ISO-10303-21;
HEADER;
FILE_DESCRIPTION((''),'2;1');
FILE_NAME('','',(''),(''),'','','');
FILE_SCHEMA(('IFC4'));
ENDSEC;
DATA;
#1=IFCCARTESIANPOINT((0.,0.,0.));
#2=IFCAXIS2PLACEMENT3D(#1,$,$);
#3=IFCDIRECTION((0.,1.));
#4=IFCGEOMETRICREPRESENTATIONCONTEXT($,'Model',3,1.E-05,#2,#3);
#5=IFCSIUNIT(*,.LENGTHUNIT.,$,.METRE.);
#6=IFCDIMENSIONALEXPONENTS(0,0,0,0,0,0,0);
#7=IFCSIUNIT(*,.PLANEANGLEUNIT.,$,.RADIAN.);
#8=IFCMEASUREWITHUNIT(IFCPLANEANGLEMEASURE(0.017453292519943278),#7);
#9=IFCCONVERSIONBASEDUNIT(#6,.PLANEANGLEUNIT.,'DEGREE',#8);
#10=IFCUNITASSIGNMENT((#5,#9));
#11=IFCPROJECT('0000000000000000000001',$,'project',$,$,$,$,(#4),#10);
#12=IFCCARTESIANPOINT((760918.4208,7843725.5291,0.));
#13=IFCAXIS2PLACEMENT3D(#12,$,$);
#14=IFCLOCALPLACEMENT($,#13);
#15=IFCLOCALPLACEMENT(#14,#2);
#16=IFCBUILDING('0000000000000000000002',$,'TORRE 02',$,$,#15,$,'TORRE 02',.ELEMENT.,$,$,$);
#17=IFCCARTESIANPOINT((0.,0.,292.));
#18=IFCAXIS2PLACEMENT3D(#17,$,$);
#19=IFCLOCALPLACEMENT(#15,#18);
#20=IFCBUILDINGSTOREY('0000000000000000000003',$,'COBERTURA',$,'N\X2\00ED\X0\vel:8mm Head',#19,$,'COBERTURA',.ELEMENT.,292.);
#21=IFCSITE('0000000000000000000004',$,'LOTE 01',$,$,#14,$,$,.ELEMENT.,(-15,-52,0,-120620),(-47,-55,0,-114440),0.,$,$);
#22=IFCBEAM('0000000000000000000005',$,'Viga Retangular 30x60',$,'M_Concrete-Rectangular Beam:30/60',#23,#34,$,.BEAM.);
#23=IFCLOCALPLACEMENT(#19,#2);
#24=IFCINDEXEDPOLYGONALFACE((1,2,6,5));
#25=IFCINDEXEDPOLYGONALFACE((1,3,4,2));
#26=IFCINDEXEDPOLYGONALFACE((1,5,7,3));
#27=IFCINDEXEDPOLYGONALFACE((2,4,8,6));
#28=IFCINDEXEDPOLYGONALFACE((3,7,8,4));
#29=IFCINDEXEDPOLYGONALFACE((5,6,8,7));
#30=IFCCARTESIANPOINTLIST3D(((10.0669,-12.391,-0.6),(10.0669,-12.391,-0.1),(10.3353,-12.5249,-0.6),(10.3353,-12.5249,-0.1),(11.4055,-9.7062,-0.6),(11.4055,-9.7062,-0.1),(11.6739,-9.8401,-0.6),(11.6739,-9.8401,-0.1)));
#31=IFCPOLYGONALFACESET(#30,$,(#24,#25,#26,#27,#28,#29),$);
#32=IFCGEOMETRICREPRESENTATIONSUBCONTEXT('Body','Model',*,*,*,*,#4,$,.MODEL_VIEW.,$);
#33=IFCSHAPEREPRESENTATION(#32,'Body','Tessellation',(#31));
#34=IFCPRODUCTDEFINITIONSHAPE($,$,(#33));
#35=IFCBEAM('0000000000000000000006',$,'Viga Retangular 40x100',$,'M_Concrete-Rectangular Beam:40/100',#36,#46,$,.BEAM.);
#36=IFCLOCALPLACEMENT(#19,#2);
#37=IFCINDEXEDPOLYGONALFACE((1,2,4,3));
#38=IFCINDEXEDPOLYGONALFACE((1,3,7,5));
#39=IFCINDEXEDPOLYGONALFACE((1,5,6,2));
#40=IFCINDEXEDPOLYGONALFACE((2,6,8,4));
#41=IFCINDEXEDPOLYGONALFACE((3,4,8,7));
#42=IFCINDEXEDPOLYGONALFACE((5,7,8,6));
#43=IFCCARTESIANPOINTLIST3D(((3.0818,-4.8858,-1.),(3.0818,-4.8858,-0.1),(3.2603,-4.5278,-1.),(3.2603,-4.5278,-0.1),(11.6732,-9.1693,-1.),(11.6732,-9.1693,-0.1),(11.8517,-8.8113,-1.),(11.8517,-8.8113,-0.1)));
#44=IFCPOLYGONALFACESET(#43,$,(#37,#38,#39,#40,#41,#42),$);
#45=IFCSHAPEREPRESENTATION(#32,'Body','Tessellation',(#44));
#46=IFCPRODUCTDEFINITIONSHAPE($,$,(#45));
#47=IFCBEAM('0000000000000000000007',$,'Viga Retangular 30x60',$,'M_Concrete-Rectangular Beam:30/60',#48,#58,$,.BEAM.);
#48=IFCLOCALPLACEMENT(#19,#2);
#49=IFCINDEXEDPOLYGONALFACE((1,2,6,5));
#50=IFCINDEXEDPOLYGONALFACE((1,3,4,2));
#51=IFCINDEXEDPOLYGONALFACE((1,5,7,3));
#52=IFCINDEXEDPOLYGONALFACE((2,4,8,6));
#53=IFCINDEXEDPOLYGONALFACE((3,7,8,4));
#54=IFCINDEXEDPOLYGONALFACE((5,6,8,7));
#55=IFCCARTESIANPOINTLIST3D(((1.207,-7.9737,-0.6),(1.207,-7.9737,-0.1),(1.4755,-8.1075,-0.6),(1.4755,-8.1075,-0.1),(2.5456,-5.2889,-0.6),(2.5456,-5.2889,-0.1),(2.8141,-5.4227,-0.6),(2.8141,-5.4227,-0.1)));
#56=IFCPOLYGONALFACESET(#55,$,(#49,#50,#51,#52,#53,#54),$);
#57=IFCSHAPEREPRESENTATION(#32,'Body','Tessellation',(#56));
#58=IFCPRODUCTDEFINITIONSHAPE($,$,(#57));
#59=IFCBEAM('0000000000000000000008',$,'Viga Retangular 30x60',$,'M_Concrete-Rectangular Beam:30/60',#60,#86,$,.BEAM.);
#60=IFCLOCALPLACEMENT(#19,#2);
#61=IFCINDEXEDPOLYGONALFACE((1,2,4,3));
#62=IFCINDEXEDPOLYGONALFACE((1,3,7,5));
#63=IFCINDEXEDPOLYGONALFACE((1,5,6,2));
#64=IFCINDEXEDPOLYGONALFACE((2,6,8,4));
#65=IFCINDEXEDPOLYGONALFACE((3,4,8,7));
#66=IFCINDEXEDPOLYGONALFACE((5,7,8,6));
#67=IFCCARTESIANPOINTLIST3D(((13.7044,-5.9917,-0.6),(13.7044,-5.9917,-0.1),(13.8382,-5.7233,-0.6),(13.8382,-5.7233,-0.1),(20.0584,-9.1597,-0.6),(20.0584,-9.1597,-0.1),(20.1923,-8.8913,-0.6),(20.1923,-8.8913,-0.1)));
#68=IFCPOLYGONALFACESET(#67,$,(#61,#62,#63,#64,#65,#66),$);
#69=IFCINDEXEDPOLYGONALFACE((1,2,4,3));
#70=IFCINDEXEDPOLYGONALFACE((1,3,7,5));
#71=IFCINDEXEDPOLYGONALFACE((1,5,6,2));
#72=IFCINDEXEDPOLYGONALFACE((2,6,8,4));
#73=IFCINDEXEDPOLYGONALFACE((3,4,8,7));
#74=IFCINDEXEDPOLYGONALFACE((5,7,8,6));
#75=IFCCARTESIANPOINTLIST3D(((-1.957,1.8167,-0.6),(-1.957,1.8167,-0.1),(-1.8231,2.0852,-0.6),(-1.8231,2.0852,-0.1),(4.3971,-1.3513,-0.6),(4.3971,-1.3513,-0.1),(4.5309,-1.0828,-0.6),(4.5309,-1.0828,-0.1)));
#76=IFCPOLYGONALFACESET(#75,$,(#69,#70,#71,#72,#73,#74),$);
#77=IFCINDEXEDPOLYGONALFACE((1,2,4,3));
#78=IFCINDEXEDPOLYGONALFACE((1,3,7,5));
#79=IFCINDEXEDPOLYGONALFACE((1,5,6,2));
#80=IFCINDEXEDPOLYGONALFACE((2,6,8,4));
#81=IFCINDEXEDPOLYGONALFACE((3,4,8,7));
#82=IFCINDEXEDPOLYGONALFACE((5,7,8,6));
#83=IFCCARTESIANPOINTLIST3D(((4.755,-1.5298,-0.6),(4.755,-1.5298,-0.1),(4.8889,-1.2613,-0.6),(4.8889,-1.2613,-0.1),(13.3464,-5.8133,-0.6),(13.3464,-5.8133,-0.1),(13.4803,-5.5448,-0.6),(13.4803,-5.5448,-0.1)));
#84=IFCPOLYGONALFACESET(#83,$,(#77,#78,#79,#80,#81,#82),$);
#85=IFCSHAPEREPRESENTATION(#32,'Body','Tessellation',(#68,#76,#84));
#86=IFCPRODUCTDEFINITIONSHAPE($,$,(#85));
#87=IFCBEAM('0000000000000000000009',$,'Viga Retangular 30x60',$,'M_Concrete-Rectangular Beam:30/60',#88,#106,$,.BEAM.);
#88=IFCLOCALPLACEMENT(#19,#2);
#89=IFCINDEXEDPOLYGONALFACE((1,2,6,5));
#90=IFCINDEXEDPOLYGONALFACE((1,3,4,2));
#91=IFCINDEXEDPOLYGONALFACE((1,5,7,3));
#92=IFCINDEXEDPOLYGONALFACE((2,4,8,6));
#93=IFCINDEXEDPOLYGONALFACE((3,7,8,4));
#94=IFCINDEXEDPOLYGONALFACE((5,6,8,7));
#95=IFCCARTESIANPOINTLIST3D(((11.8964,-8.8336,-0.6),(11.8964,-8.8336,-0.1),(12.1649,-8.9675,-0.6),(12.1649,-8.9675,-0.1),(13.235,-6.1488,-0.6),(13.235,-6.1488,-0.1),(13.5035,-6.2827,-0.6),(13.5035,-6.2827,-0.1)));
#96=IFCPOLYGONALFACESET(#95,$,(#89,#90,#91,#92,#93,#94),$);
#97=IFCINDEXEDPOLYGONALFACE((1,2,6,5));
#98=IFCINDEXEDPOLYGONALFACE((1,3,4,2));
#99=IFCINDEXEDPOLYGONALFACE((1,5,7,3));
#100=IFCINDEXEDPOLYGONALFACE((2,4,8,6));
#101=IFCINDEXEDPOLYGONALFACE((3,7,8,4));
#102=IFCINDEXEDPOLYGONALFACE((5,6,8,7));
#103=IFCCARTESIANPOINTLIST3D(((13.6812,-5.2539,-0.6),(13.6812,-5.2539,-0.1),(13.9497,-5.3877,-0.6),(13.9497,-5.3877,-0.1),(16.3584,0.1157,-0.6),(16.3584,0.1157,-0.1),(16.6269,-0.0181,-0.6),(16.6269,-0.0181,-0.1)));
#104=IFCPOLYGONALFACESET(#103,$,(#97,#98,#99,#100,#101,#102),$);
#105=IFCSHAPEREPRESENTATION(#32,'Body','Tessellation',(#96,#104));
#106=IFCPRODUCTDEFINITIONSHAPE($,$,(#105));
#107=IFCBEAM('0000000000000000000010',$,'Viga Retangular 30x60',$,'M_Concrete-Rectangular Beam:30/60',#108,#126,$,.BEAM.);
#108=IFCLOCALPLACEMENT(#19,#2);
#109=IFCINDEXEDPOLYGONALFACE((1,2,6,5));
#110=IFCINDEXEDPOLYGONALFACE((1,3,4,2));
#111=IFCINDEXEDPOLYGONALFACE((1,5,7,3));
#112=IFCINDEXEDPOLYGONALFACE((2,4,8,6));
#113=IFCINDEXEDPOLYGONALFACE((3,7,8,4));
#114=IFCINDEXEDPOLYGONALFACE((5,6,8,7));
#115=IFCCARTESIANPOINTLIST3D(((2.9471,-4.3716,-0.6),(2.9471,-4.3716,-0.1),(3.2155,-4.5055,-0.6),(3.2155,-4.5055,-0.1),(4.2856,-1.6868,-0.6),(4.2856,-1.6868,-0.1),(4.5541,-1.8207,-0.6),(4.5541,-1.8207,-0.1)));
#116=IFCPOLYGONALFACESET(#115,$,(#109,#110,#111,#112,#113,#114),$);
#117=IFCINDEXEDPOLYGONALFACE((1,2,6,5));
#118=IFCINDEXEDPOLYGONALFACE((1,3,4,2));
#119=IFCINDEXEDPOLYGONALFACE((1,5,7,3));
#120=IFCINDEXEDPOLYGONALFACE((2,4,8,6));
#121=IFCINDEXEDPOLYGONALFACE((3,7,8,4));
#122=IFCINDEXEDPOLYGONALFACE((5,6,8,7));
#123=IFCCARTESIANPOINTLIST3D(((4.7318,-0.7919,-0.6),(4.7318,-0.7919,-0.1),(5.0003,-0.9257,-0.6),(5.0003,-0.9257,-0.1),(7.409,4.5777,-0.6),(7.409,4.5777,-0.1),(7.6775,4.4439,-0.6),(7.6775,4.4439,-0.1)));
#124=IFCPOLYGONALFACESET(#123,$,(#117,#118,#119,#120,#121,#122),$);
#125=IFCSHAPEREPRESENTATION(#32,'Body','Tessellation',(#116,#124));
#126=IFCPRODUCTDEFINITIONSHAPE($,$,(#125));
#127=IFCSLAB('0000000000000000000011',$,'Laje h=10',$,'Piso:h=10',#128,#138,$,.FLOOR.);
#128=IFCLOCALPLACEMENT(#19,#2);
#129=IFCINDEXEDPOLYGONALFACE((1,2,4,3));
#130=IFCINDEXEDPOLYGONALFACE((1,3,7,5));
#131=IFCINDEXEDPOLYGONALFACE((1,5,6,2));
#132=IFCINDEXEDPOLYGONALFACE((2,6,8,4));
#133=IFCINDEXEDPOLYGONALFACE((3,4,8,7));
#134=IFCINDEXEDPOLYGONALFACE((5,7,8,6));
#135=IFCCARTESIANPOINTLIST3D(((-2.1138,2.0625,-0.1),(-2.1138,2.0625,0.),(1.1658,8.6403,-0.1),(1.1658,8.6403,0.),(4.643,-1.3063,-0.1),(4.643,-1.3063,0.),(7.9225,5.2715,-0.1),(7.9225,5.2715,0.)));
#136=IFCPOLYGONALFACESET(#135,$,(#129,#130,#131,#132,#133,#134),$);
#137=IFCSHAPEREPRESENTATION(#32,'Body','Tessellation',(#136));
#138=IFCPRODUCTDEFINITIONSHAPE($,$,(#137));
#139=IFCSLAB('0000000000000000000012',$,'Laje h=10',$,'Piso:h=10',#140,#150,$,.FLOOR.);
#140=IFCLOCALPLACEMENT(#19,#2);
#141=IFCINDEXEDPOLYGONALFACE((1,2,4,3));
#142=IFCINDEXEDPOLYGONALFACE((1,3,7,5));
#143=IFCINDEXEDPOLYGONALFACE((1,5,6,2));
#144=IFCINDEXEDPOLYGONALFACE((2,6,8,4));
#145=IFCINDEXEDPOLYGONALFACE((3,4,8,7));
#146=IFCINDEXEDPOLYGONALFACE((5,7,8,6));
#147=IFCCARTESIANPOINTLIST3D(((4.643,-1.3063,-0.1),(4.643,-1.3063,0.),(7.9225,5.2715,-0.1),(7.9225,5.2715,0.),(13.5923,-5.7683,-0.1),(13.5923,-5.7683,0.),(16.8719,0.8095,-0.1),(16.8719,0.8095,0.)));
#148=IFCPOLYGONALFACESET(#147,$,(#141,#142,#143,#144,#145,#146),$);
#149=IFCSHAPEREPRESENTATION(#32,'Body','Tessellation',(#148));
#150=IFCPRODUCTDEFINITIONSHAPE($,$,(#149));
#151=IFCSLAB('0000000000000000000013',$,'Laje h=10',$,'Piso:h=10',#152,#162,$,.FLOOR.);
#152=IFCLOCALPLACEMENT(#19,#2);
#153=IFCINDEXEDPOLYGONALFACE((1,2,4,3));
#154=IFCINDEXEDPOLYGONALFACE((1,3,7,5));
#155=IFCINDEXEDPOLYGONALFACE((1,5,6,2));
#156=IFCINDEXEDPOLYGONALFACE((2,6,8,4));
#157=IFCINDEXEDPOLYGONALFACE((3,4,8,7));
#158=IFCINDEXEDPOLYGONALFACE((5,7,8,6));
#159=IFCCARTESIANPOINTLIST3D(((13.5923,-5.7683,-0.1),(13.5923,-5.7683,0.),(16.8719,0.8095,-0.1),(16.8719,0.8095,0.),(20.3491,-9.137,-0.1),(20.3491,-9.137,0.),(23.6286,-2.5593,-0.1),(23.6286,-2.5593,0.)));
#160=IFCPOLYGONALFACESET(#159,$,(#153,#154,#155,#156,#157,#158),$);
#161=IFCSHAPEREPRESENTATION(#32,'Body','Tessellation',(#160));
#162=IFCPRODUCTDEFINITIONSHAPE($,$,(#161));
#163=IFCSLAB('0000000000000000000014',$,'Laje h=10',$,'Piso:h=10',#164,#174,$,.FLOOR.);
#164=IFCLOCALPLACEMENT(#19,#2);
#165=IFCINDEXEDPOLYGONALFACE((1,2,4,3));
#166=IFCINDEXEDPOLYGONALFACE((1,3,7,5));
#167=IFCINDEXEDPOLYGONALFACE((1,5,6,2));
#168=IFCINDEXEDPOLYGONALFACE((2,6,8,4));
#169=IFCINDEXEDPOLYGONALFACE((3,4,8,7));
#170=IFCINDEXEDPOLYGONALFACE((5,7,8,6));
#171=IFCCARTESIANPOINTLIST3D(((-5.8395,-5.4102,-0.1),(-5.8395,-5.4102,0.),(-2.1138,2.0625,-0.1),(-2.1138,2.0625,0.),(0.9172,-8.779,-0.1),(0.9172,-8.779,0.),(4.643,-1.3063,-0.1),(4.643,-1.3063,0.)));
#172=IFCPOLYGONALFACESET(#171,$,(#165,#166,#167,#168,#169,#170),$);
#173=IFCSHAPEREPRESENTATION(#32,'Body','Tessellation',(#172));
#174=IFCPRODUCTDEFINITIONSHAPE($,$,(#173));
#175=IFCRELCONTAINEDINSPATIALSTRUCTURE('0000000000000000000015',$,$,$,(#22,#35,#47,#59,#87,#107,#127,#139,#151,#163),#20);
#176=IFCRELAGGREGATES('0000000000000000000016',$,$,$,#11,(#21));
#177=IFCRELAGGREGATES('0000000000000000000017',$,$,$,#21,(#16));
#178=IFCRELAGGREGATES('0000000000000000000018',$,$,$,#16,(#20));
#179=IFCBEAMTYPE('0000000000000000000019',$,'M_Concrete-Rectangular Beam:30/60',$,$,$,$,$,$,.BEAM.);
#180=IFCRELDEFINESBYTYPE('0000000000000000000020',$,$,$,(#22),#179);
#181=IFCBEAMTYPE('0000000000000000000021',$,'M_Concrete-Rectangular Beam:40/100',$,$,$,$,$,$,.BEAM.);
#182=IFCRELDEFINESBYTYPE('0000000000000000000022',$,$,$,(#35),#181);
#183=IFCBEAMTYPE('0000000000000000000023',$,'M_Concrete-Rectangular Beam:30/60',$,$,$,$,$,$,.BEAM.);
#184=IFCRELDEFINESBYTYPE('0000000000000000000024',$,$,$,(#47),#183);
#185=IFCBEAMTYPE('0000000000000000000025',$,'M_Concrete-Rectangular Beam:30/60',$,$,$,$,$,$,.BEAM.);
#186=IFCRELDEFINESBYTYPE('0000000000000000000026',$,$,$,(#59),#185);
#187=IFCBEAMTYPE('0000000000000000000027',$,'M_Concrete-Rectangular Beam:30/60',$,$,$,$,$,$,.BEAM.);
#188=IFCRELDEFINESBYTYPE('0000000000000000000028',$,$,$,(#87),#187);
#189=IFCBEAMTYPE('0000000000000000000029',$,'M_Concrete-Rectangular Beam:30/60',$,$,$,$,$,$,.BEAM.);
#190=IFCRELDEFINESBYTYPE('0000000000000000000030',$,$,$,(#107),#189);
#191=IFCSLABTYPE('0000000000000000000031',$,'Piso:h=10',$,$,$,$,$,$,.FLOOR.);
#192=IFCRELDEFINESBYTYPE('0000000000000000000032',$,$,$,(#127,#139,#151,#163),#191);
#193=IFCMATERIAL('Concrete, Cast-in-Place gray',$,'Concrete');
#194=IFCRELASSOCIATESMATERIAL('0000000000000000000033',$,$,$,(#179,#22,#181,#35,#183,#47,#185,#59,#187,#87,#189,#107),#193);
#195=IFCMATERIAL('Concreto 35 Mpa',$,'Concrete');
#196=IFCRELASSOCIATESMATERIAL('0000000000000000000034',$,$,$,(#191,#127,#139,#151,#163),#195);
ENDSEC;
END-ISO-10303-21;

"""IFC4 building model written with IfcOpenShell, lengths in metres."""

from ifc_helpers import new_model, entity, si_unit, converted_unit, direction, frame, origin, place, context, subcontext, project, spatial, indexed_curve, outline, extrude, source, transform, mapped, material, type_object, type_shapes, element, save


model = new_model("IFC4")

# Units and contexts
model_context = context("Model", 3, precision=1e-05, world=origin(), true_north=direction((0.0, 1.0)))
body_context = subcontext(model_context, "Body", "Model", "MODEL_VIEW")
ifc_project = project(units=[si_unit("LENGTHUNIT", "METRE"), converted_unit("PLANEANGLEUNIT", "DEGREE", entity("IfcPlaneAngleMeasure", 0.017453292519943278), si_unit("PLANEANGLEUNIT", "RADIAN"), dimensions=[0, 0, 0, 0, 0, 0, 0])], contexts=[model_context])

# Site, building, storey
site_placement = place(None, frame((760918.4208, 7843725.5291, 0.0)))
site = spatial("IfcSite", under=ifc_project, at=site_placement, Name="LOTE 01", CompositionType="ELEMENT", RefLatitude=(-15, -52, 0, -120620), RefLongitude=(-47, -55, 0, -114440), RefElevation=0.0)
building_placement = place(site_placement, origin())
building = spatial("IfcBuilding", under=site, at=building_placement, Name="TORRE 02", LongName="TORRE 02", CompositionType="ELEMENT")
storey_placement = place(building_placement, frame((0.0, 0.0, 292.0)))
storey = spatial("IfcBuildingStorey", under=building, at=storey_placement, Name="COBERTURA", ObjectType="Nível:8mm Head", LongName="COBERTURA", CompositionType="ELEMENT", Elevation=292.0)

# Beams
ifc_material_1 = material(Name="Concrete, Cast-in-Place gray", Category="Concrete")
beam_type_1 = type_object("IfcBeamType", Name="M_Concrete-Rectangular Beam:30/60", PredefinedType="BEAM", material=ifc_material_1)
shared_shape_1 = source(origin(), body_context, "Body", "SweptSolid", [
    extrude(outline(indexed_curve([(-0.25, -0.15), (0.25, -0.15), (0.25, 0.15), (-0.25, 0.15), (-0.25, -0.15)], self_intersect=False)), frame((10.2011, -12.458, 291.65), z_axis=(0.446198, 0.894934, 0.0), x_axis=(0.0, 0.0, 1.0)), (0.0, 0.0, 1.0), 3.0),
])
type_shapes(beam_type_1, [shared_shape_1])
beam_1_placement = place(storey_placement, frame((0.0, 0.0, -292.0)))
element("IfcBeam", 1, at=beam_1_placement, inside=storey, type_object=beam_type_1, material=ifc_material_1, Name="Viga Retangular 30x60", ObjectType="M_Concrete-Rectangular Beam:30/60", PredefinedType="BEAM", context=body_context, shape_type="MappedRepresentation", body=[
    mapped(shared_shape_1, transform((0.0, 0.0, 0.0), scale=1.0)),
])
beam_type_2 = type_object("IfcBeamType", Name="M_Concrete-Rectangular Beam:40/100", PredefinedType="BEAM", material=ifc_material_1)
shared_shape_2 = source(origin(), body_context, "Body", "SweptSolid", [
    extrude(outline(indexed_curve([(-0.45, -0.2), (0.45, -0.2), (0.45, 0.2), (-0.45, 0.2), (-0.45, -0.2)], self_intersect=False)), frame((11.7624, -8.9903, 291.45), z_axis=(-0.894934, 0.446198, 0.0), x_axis=(0.0, 0.0, 1.0)), (0.0, 0.0, 1.0), 9.6),
])
type_shapes(beam_type_2, [shared_shape_2])
beam_2_placement = place(storey_placement, frame((0.0, 0.0, -292.0)))
element("IfcBeam", 2, at=beam_2_placement, inside=storey, type_object=beam_type_2, material=ifc_material_1, Name="Viga Retangular 40x100", ObjectType="M_Concrete-Rectangular Beam:40/100", PredefinedType="BEAM", context=body_context, shape_type="MappedRepresentation", body=[
    mapped(shared_shape_2, transform((0.0, 0.0, 0.0), scale=1.0)),
])
beam_type_3 = type_object("IfcBeamType", Name="M_Concrete-Rectangular Beam:30/60", PredefinedType="BEAM", material=ifc_material_1)
shared_shape_3 = source(origin(), body_context, "Body", "SweptSolid", [
    extrude(outline(indexed_curve([(-0.25, -0.15), (0.25, -0.15), (0.25, 0.15), (-0.25, 0.15), (-0.25, -0.15)], self_intersect=False)), frame((2.6798, -5.3558, 291.65), z_axis=(-0.446198, -0.894934, 0.0), x_axis=(0.0, 0.0, -1.0)), (0.0, 0.0, 1.0), 3.0),
])
type_shapes(beam_type_3, [shared_shape_3])
beam_3_placement = place(storey_placement, frame((0.0, 0.0, -292.0)))
element("IfcBeam", 3, at=beam_3_placement, inside=storey, type_object=beam_type_3, material=ifc_material_1, Name="Viga Retangular 30x60", ObjectType="M_Concrete-Rectangular Beam:30/60", PredefinedType="BEAM", context=body_context, shape_type="MappedRepresentation", body=[
    mapped(shared_shape_3, transform((0.0, 0.0, 0.0), scale=1.0)),
])
beam_type_4 = type_object("IfcBeamType", Name="M_Concrete-Rectangular Beam:30/60", PredefinedType="BEAM", material=ifc_material_1)
shared_shape_4 = source(origin(), body_context, "Body", "SweptSolid", [
    extrude(outline(indexed_curve([(-0.25, -0.15), (0.25, -0.15), (0.25, 0.15), (-0.25, 0.15), (-0.25, -0.15)], self_intersect=False)), frame((13.7713, -5.8575, 291.65), z_axis=(0.894934, -0.446198, 0.0), x_axis=(0.0, 0.0, -1.0)), (0.0, 0.0, 1.0), 7.1),
    extrude(outline(indexed_curve([(-0.25, -0.15), (0.25, -0.15), (0.25, 0.15), (-0.25, 0.15), (-0.25, -0.15)], self_intersect=False)), frame((-1.89, 1.951, 291.65), z_axis=(0.894934, -0.446198, 0.0), x_axis=(0.0, 0.0, -1.0)), (0.0, 0.0, 1.0), 7.1),
    extrude(outline(indexed_curve([(-0.25, -0.15), (0.25, -0.15), (0.25, 0.15), (-0.25, 0.15), (-0.25, -0.15)], self_intersect=False)), frame((4.822, -1.3955, 291.65), z_axis=(0.894934, -0.446198, 0.0), x_axis=(0.0, 0.0, -1.0)), (0.0, 0.0, 1.0), 9.6),
])
type_shapes(beam_type_4, [shared_shape_4])
beam_4_placement = place(storey_placement, frame((0.0, 0.0, -292.0)))
element("IfcBeam", 4, at=beam_4_placement, inside=storey, type_object=beam_type_4, material=ifc_material_1, Name="Viga Retangular 30x60", ObjectType="M_Concrete-Rectangular Beam:30/60", PredefinedType="BEAM", context=body_context, shape_type="MappedRepresentation", body=[
    mapped(shared_shape_4, transform((0.0, 0.0, 0.0), scale=1.0)),
])
beam_type_5 = type_object("IfcBeamType", Name="M_Concrete-Rectangular Beam:30/60", PredefinedType="BEAM", material=ifc_material_1)
shared_shape_5 = source(origin(), body_context, "Body", "SweptSolid", [
    extrude(outline(indexed_curve([(-0.25, -0.15), (0.25, -0.15), (0.25, 0.15), (-0.25, 0.15), (-0.25, -0.15)], self_intersect=False)), frame((12.0306, -8.9005, 291.65), z_axis=(0.446198, 0.894934, 0.0), x_axis=(0.0, 0.0, 1.0)), (0.0, 0.0, 1.0), 3.0),
    extrude(outline(indexed_curve([(-0.25, -0.15), (0.25, -0.15), (0.25, 0.15), (-0.25, 0.15), (-0.25, -0.15)], self_intersect=False)), frame((13.8154, -5.3208, 291.65), z_axis=(0.446198, 0.894934, 0.0), x_axis=(0.0, 0.0, 1.0)), (0.0, 0.0, 1.0), 6.0),
])
type_shapes(beam_type_5, [shared_shape_5])
beam_5_placement = place(storey_placement, frame((0.0, 0.0, -292.0)))
element("IfcBeam", 5, at=beam_5_placement, inside=storey, type_object=beam_type_5, material=ifc_material_1, Name="Viga Retangular 30x60", ObjectType="M_Concrete-Rectangular Beam:30/60", PredefinedType="BEAM", context=body_context, shape_type="MappedRepresentation", body=[
    mapped(shared_shape_5, transform((0.0, 0.0, 0.0), scale=1.0)),
])
beam_type_6 = type_object("IfcBeamType", Name="M_Concrete-Rectangular Beam:30/60", PredefinedType="BEAM", material=ifc_material_1)
shared_shape_6 = source(origin(), body_context, "Body", "SweptSolid", [
    extrude(outline(indexed_curve([(-0.25, -0.15), (0.25, -0.15), (0.25, 0.15), (-0.25, 0.15), (-0.25, -0.15)], self_intersect=False)), frame((3.0813, -4.4385, 291.65), z_axis=(0.446198, 0.894934, 0.0), x_axis=(0.0, 0.0, 1.0)), (0.0, 0.0, 1.0), 3.0),
    extrude(outline(indexed_curve([(-0.25, -0.15), (0.25, -0.15), (0.25, 0.15), (-0.25, 0.15), (-0.25, -0.15)], self_intersect=False)), frame((4.8661, -0.8588, 291.65), z_axis=(0.446198, 0.894934, 0.0), x_axis=(0.0, 0.0, 1.0)), (0.0, 0.0, 1.0), 6.0),
])
type_shapes(beam_type_6, [shared_shape_6])
beam_6_placement = place(storey_placement, frame((0.0, 0.0, -292.0)))
element("IfcBeam", 6, at=beam_6_placement, inside=storey, type_object=beam_type_6, material=ifc_material_1, Name="Viga Retangular 30x60", ObjectType="M_Concrete-Rectangular Beam:30/60", PredefinedType="BEAM", context=body_context, shape_type="MappedRepresentation", body=[
    mapped(shared_shape_6, transform((0.0, 0.0, 0.0), scale=1.0)),
])

# Slabs
ifc_material_2 = material(Name="Concreto 35 Mpa", Category="Concrete")
slab_type = type_object("IfcSlabType", Name="Piso:h=10", PredefinedType="FLOOR", material=ifc_material_2)
slab_1_placement = place(storey_placement, origin())
element("IfcSlab", 7, at=slab_1_placement, inside=storey, type_object=slab_type, material=ifc_material_2, Name="Laje h=10", ObjectType="Piso:h=10", PredefinedType="FLOOR", context=body_context, shape_type="SweptSolid", body=[
    extrude(outline(indexed_curve([(-3.675, -3.775), (3.675, -3.775), (3.675, 3.775), (-3.675, 3.775), (-3.675, -3.775)], self_intersect=False)), frame((2.9044, 3.667, 0.0), z_axis=(0.0, 0.0, -1.0), x_axis=(-0.446198, -0.894934, 0.0)), (0.0, 0.0, 1.0), 0.1),
])
slab_2_placement = place(storey_placement, origin())
element("IfcSlab", 8, at=slab_2_placement, inside=storey, type_object=slab_type, material=ifc_material_2, Name="Laje h=10", ObjectType="Piso:h=10", PredefinedType="FLOOR", context=body_context, shape_type="SweptSolid", body=[
    extrude(outline(indexed_curve([(-3.675, -5.0), (3.675, -5.0), (3.675, 5.0), (-3.675, 5.0), (-3.675, -5.0)], self_intersect=False)), frame((10.7574, -0.2484, 0.0), z_axis=(0.0, 0.0, -1.0), x_axis=(-0.446198, -0.894934, 0.0)), (0.0, 0.0, 1.0), 0.1),
])
slab_3_placement = place(storey_placement, origin())
element("IfcSlab", 9, at=slab_3_placement, inside=storey, type_object=slab_type, material=ifc_material_2, Name="Laje h=10", ObjectType="Piso:h=10", PredefinedType="FLOOR", context=body_context, shape_type="SweptSolid", body=[
    extrude(outline(indexed_curve([(-3.675, -3.775), (3.675, -3.775), (3.675, 3.775), (-3.675, 3.775), (-3.675, -3.775)], self_intersect=False)), frame((18.6105, -4.1638, 0.0), z_axis=(0.0, 0.0, -1.0), x_axis=(-0.446198, -0.894934, 0.0)), (0.0, 0.0, 1.0), 0.1),
])
slab_4_placement = place(storey_placement, origin())
element("IfcSlab", 10, at=slab_4_placement, inside=storey, type_object=slab_type, material=ifc_material_2, Name="Laje h=10", ObjectType="Piso:h=10", PredefinedType="FLOOR", context=body_context, shape_type="SweptSolid", body=[
    extrude(outline(indexed_curve([(-4.175, -3.775), (4.175, -3.775), (4.175, 3.775), (-4.175, 3.775), (-4.175, -3.775)], self_intersect=False)), frame((-0.5983, -3.3582, 0.0), z_axis=(0.0, 0.0, -1.0), x_axis=(-0.446198, -0.894934, 0.0)), (0.0, 0.0, 1.0), 0.1),
])

save(model, "model.ifc")
